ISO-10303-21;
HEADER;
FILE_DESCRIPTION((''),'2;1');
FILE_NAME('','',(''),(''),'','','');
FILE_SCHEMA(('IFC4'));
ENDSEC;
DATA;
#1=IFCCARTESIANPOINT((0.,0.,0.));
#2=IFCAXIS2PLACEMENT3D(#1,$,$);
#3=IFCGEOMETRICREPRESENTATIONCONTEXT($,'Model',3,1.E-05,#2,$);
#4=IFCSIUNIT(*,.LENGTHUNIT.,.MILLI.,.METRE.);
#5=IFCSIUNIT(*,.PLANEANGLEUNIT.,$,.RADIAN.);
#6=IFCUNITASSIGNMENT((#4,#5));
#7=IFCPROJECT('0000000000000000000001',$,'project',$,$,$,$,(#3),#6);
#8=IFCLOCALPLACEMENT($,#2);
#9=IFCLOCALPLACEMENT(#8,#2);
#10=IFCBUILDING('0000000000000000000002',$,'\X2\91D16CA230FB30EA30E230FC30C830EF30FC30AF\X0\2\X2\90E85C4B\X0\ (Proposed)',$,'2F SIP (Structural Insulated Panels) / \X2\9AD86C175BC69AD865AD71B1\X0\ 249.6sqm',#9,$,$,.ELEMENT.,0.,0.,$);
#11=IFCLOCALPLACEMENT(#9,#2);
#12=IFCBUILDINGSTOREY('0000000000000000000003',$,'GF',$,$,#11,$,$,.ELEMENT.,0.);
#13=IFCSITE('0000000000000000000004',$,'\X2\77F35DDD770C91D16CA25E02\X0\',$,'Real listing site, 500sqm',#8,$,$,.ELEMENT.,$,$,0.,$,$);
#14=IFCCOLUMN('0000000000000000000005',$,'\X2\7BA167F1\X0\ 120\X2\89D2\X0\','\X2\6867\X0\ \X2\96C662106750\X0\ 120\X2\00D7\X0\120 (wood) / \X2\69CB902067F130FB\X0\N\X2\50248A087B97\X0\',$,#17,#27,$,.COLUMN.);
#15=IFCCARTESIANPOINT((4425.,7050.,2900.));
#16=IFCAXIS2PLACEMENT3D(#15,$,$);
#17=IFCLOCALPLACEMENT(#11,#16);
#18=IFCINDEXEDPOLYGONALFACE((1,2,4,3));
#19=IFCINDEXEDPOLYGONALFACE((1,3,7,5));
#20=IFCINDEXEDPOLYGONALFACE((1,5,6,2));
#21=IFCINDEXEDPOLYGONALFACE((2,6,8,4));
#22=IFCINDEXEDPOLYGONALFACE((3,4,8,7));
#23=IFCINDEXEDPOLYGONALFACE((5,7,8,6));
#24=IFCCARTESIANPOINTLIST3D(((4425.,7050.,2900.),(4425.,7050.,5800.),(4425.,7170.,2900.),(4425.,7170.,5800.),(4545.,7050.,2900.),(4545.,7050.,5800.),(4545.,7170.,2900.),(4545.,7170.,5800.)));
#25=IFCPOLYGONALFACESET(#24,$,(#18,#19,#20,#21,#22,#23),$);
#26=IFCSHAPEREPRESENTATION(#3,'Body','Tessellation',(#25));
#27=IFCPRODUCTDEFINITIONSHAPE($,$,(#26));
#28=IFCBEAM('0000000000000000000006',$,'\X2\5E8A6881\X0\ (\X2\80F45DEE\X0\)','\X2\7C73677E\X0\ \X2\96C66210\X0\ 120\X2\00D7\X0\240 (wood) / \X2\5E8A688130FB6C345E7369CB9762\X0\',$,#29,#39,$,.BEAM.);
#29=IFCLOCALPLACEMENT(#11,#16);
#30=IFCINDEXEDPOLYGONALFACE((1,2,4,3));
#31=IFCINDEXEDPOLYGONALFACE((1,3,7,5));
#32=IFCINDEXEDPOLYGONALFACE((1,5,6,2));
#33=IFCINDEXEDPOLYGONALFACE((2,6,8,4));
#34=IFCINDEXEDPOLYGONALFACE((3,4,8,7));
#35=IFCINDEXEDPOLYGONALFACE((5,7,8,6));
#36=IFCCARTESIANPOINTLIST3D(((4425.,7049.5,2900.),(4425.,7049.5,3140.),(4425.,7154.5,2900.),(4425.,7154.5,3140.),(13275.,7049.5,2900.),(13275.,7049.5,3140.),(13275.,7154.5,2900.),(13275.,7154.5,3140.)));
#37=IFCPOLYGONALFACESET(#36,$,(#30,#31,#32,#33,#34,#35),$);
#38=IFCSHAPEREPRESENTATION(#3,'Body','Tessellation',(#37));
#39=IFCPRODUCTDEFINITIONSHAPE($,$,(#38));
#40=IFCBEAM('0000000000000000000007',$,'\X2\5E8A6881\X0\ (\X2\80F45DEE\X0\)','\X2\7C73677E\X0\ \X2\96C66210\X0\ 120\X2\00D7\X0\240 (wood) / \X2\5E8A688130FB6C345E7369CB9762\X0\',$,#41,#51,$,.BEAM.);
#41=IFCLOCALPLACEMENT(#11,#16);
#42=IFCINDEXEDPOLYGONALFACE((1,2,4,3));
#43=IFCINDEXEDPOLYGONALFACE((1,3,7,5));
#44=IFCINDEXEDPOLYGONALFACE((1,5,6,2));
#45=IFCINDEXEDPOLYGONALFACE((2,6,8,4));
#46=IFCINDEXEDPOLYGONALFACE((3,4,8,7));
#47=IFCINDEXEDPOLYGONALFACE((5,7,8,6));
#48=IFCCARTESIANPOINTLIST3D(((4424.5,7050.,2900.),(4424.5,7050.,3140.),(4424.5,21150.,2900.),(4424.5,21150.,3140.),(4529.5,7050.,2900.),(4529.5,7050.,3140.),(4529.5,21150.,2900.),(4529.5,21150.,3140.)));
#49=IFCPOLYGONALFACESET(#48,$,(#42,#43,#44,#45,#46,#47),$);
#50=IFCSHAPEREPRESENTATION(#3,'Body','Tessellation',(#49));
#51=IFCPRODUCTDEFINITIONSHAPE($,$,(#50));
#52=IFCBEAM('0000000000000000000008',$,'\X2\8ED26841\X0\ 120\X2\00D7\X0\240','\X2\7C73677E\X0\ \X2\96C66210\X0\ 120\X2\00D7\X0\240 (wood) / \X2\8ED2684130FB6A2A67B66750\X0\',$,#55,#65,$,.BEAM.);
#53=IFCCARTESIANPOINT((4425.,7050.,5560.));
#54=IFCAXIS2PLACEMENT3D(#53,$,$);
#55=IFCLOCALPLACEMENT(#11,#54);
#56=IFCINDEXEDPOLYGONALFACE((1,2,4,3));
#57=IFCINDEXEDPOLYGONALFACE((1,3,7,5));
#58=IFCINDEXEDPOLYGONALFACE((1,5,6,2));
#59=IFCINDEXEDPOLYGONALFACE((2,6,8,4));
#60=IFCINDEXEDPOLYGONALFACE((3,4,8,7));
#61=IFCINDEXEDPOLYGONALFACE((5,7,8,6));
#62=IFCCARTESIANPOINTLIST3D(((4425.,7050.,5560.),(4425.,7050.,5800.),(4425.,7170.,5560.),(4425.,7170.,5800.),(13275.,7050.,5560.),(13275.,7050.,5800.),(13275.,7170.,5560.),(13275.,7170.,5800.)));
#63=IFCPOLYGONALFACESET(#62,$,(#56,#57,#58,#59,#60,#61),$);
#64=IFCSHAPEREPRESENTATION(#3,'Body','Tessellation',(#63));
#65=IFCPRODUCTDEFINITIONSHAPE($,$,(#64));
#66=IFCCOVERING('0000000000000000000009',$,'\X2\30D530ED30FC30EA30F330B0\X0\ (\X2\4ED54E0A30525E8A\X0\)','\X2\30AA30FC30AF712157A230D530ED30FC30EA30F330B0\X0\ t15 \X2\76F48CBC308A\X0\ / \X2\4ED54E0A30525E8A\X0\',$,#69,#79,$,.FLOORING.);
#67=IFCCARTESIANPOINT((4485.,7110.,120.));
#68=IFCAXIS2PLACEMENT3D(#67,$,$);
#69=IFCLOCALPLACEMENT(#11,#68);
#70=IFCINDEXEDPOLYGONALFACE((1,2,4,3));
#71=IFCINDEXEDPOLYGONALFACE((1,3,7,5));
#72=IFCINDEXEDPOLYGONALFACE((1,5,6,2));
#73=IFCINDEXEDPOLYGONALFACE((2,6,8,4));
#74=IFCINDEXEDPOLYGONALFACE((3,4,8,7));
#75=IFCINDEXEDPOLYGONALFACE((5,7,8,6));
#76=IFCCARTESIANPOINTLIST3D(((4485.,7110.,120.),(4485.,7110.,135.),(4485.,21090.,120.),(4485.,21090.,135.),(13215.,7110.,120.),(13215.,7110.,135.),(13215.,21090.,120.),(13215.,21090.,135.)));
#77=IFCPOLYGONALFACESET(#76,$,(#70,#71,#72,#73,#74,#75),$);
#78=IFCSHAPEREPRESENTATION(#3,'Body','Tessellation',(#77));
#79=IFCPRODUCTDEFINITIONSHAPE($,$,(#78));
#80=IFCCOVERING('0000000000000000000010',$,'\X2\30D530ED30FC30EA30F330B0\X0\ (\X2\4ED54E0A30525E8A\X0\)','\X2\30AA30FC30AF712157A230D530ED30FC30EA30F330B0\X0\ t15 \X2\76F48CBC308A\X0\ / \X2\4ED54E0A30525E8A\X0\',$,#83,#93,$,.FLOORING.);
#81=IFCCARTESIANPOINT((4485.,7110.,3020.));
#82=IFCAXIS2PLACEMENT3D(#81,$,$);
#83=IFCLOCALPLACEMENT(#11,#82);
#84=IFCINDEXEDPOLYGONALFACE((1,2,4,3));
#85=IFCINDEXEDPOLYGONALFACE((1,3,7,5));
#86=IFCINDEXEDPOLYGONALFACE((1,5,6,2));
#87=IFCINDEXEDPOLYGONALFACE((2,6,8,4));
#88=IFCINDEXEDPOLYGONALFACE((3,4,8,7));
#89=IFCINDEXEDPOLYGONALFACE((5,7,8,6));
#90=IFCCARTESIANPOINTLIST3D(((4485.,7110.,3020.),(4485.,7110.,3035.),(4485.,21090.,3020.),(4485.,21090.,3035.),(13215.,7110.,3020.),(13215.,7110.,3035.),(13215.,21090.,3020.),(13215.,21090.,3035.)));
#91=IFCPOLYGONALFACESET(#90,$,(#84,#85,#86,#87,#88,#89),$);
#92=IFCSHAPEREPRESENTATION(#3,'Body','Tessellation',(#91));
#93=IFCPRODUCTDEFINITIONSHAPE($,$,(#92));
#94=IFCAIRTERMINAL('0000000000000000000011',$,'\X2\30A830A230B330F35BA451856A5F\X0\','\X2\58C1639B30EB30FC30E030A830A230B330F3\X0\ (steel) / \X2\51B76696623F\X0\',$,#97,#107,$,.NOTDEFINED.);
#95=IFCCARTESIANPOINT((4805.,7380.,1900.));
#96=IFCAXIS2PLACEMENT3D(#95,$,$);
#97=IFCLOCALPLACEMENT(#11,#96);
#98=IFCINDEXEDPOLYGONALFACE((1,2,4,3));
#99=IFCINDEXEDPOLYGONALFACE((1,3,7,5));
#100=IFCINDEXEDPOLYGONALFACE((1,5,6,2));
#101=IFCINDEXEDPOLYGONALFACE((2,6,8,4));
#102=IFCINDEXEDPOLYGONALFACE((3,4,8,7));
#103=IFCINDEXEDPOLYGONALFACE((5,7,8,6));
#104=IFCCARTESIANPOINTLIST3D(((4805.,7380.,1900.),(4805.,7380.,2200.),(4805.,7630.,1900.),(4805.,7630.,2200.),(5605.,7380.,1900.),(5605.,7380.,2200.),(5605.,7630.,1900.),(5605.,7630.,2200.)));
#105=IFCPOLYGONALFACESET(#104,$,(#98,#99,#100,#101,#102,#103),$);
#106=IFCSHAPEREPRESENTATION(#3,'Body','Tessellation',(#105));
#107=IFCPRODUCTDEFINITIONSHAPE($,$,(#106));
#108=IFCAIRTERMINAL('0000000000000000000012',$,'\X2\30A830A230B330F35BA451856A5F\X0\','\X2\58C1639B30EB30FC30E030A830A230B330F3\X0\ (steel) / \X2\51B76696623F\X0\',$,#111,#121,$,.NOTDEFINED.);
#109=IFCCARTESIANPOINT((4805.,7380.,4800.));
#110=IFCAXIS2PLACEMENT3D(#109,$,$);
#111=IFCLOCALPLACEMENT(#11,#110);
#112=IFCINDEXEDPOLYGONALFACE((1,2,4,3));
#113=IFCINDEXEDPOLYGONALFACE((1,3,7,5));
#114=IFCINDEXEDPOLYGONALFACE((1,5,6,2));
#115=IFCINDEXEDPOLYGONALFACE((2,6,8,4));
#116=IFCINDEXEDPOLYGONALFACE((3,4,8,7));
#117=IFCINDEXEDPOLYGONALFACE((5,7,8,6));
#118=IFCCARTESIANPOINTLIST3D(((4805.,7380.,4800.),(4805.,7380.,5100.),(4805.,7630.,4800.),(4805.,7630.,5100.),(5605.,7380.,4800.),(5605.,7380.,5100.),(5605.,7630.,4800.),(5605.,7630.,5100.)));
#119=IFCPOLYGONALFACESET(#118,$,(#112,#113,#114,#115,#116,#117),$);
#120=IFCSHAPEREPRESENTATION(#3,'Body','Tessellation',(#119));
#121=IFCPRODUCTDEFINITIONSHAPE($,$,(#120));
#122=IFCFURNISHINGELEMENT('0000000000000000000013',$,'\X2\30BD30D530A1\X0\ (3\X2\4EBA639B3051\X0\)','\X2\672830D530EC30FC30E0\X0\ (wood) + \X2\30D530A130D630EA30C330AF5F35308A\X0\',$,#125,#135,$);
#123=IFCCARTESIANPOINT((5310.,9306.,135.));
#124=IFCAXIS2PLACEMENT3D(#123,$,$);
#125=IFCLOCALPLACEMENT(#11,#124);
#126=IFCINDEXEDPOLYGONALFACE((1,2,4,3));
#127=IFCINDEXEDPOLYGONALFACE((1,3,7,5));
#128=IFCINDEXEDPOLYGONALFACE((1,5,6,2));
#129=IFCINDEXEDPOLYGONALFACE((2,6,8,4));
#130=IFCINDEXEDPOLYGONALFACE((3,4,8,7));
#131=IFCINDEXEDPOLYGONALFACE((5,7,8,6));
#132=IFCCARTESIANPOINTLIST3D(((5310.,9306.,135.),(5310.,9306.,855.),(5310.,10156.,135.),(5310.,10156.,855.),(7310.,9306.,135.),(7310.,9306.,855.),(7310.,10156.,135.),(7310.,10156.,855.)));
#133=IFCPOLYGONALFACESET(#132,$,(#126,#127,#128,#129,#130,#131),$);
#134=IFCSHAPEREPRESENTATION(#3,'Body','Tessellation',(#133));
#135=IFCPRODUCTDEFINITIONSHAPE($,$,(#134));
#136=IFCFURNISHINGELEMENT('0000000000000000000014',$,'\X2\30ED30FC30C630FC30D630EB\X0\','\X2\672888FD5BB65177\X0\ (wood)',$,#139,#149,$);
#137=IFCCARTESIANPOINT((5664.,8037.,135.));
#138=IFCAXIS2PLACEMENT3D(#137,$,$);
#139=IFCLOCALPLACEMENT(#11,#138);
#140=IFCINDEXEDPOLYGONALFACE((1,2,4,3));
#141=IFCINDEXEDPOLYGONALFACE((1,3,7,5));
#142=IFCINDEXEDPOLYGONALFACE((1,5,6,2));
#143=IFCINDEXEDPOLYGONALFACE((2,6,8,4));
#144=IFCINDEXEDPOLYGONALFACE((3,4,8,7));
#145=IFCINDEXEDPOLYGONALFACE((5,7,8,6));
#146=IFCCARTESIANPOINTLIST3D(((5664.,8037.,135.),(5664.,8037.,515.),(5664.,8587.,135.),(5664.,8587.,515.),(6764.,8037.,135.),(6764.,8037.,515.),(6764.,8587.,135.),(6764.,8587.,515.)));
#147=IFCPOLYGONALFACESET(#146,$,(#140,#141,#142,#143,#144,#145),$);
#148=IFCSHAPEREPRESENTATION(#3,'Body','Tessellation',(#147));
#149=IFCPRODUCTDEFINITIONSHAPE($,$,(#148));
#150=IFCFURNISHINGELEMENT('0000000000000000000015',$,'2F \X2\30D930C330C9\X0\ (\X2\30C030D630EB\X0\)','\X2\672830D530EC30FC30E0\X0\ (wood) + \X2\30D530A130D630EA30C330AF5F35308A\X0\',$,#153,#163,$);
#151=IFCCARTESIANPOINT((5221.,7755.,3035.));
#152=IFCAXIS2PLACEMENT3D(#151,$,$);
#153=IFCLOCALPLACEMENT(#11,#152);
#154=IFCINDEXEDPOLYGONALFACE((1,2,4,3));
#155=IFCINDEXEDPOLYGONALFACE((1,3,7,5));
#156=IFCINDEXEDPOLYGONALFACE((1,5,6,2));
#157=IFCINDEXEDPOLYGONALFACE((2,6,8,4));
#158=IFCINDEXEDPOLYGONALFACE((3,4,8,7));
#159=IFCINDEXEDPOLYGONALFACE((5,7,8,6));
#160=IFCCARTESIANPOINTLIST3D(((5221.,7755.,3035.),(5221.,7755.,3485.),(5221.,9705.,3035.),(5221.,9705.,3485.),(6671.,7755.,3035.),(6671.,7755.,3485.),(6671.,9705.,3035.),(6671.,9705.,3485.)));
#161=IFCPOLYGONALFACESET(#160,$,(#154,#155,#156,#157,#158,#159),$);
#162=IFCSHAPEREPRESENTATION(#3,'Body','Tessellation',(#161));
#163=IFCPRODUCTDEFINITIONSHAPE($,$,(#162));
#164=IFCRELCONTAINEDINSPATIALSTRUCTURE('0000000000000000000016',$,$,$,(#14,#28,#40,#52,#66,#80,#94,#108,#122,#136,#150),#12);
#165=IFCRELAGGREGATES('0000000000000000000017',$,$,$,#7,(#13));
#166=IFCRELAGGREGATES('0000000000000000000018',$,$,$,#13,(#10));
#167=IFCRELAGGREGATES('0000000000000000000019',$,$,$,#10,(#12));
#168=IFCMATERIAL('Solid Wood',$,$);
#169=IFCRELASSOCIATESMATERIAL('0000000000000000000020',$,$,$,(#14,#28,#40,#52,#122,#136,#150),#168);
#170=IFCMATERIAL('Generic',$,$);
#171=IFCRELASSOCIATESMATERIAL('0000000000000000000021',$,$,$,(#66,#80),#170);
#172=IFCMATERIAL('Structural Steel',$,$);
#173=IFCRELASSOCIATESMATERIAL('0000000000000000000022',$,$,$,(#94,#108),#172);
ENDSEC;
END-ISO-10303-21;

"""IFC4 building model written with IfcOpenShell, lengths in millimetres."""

from ifc_helpers import new_model, si_unit, frame, frame_2d, origin, place, context, project, spatial, rectangle, extrude, material, element, save


model = new_model("IFC4")

# Units and contexts
model_context = context("Model", 3, precision=1e-05, world=origin())
ifc_project = project(units=[si_unit("LENGTHUNIT", "METRE", prefix="MILLI"), si_unit("PLANEANGLEUNIT", "RADIAN")], contexts=[model_context])

# Site, building, storey
site_placement = place(None, origin())
site = spatial("IfcSite", under=ifc_project, at=site_placement, Name="石川県金沢市", ObjectType="Real listing site, 500sqm", CompositionType="ELEMENT", RefElevation=0.0)
building_placement = place(site_placement, origin())
building = spatial("IfcBuilding", under=site, at=building_placement, Name="金沢・リモートワーク2部屋 (Proposed)", ObjectType="2F SIP (Structural Insulated Panels) / 高気密高断熱 249.6sqm", CompositionType="ELEMENT", ElevationOfRefHeight=0.0, ElevationOfTerrain=0.0)
storey_placement = place(building_placement, origin())
storey = spatial("IfcBuildingStorey", under=building, at=storey_placement, Name="GF", CompositionType="ELEMENT", Elevation=0.0)

# Column
ifc_material_1 = material(Name="Solid Wood")
column_1_placement = place(storey_placement, frame((4425.0, 7050.0, 2900.0)))
element("IfcColumn", 1, at=column_1_placement, inside=storey, material=ifc_material_1, Name="管柱 120角", Description="桧 集成材 120×120 (wood) / 構造柱・N値計算", PredefinedType="COLUMN", context=model_context, shape_type="SweptSolid", body=[
    extrude(rectangle(XDim=120.0, YDim=120.0, at=frame_2d((60.0, 60.0))), frame((4425.0, 7050.0, 2900.0)), (0.0, 0.0, 1.0), 2900.0),
])

# Beams
beam_1_placement = place(storey_placement, frame((4425.0, 7050.0, 2900.0)))
element("IfcBeam", 2, at=beam_1_placement, inside=storey, material=ifc_material_1, Name="床梁 (胴差)", Description="米松 集成 120×240 (wood) / 床梁・水平構面", PredefinedType="BEAM", context=model_context, shape_type="SweptSolid", body=[
    extrude(rectangle(XDim=8850.0, YDim=105.0, at=frame_2d((4425.0, 52.0))), frame((4425.0, 7050.0, 2900.0)), (0.0, 0.0, 1.0), 240.0),
])
beam_2_placement = place(storey_placement, frame((4425.0, 7050.0, 2900.0)))
element("IfcBeam", 3, at=beam_2_placement, inside=storey, material=ifc_material_1, Name="床梁 (胴差)", Description="米松 集成 120×240 (wood) / 床梁・水平構面", PredefinedType="BEAM", context=model_context, shape_type="SweptSolid", body=[
    extrude(rectangle(XDim=105.0, YDim=14100.0, at=frame_2d((52.0, 7050.0))), frame((4425.0, 7050.0, 2900.0)), (0.0, 0.0, 1.0), 240.0),
])
beam_3_placement = place(storey_placement, frame((4425.0, 7050.0, 5560.0)))
element("IfcBeam", 4, at=beam_3_placement, inside=storey, material=ifc_material_1, Name="軒桁 120×240", Description="米松 集成 120×240 (wood) / 軒桁・横架材", PredefinedType="BEAM", context=model_context, shape_type="SweptSolid", body=[
    extrude(rectangle(XDim=8850.0, YDim=120.0, at=frame_2d((4425.0, 60.0))), frame((4425.0, 7050.0, 5560.0)), (0.0, 0.0, 1.0), 240.0),
])

# Coverings
ifc_material_2 = material(Name="Generic")
covering_1_placement = place(storey_placement, frame((4485.0, 7110.0, 120.0)))
element("IfcCovering", 5, at=covering_1_placement, inside=storey, material=ifc_material_2, Name="フローリング (仕上げ床)", Description="オーク無垢フローリング t15 直貼り / 仕上げ床", PredefinedType="FLOORING", context=model_context, shape_type="SweptSolid", body=[
    extrude(rectangle(XDim=8730.0, YDim=13980.0, at=frame_2d((4365.0, 6990.0))), frame((4485.0, 7110.0, 120.0)), (0.0, 0.0, 1.0), 15.0),
])
covering_2_placement = place(storey_placement, frame((4485.0, 7110.0, 3020.0)))
element("IfcCovering", 6, at=covering_2_placement, inside=storey, material=ifc_material_2, Name="フローリング (仕上げ床)", Description="オーク無垢フローリング t15 直貼り / 仕上げ床", PredefinedType="FLOORING", context=model_context, shape_type="SweptSolid", body=[
    extrude(rectangle(XDim=8730.0, YDim=13980.0, at=frame_2d((4365.0, 6990.0))), frame((4485.0, 7110.0, 3020.0)), (0.0, 0.0, 1.0), 15.0),
])

# Air terminals
ifc_material_3 = material(Name="Structural Steel")
air_terminal_1_placement = place(storey_placement, frame((4805.0, 7380.0, 1900.0)))
element("IfcAirTerminal", 7, at=air_terminal_1_placement, inside=storey, material=ifc_material_3, Name="エアコン室内機", Description="壁掛ルームエアコン (steel) / 冷暖房", PredefinedType="NOTDEFINED", context=model_context, shape_type="SweptSolid", body=[
    extrude(rectangle(XDim=800.0, YDim=250.0, at=frame_2d((400.0, 125.0))), frame((4805.0, 7380.0, 1900.0)), (0.0, 0.0, 1.0), 300.0),
])
air_terminal_2_placement = place(storey_placement, frame((4805.0, 7380.0, 4800.0)))
element("IfcAirTerminal", 8, at=air_terminal_2_placement, inside=storey, material=ifc_material_3, Name="エアコン室内機", Description="壁掛ルームエアコン (steel) / 冷暖房", PredefinedType="NOTDEFINED", context=model_context, shape_type="SweptSolid", body=[
    extrude(rectangle(XDim=800.0, YDim=250.0, at=frame_2d((400.0, 125.0))), frame((4805.0, 7380.0, 4800.0)), (0.0, 0.0, 1.0), 300.0),
])

# Furnishing elements
furnishing_1_placement = place(storey_placement, frame((5310.0, 9306.0, 135.0)))
element("IfcFurnishingElement", 9, at=furnishing_1_placement, inside=storey, material=ifc_material_1, Name="ソファ (3人掛け)", Description="木フレーム (wood) + ファブリック張り", context=model_context, shape_type="SweptSolid", body=[
    extrude(rectangle(XDim=2000.0, YDim=850.0, at=frame_2d((1000.0, 425.0))), frame((5310.0, 9306.0, 135.0)), (0.0, 0.0, 1.0), 720.0),
])
furnishing_2_placement = place(storey_placement, frame((5664.0, 8037.0, 135.0)))
element("IfcFurnishingElement", 10, at=furnishing_2_placement, inside=storey, material=ifc_material_1, Name="ローテーブル", Description="木製家具 (wood)", context=model_context, shape_type="SweptSolid", body=[
    extrude(rectangle(XDim=1100.0, YDim=550.0, at=frame_2d((550.0, 275.0))), frame((5664.0, 8037.0, 135.0)), (0.0, 0.0, 1.0), 380.0),
])
furnishing_3_placement = place(storey_placement, frame((5221.0, 7755.0, 3035.0)))
element("IfcFurnishingElement", 11, at=furnishing_3_placement, inside=storey, material=ifc_material_1, Name="2F ベッド (ダブル)", Description="木フレーム (wood) + ファブリック張り", context=model_context, shape_type="SweptSolid", body=[
    extrude(rectangle(XDim=1450.0, YDim=1950.0, at=frame_2d((725.0, 975.0))), frame((5221.0, 7755.0, 3035.0)), (0.0, 0.0, 1.0), 450.0),
])

save(model, "model.ifc")
